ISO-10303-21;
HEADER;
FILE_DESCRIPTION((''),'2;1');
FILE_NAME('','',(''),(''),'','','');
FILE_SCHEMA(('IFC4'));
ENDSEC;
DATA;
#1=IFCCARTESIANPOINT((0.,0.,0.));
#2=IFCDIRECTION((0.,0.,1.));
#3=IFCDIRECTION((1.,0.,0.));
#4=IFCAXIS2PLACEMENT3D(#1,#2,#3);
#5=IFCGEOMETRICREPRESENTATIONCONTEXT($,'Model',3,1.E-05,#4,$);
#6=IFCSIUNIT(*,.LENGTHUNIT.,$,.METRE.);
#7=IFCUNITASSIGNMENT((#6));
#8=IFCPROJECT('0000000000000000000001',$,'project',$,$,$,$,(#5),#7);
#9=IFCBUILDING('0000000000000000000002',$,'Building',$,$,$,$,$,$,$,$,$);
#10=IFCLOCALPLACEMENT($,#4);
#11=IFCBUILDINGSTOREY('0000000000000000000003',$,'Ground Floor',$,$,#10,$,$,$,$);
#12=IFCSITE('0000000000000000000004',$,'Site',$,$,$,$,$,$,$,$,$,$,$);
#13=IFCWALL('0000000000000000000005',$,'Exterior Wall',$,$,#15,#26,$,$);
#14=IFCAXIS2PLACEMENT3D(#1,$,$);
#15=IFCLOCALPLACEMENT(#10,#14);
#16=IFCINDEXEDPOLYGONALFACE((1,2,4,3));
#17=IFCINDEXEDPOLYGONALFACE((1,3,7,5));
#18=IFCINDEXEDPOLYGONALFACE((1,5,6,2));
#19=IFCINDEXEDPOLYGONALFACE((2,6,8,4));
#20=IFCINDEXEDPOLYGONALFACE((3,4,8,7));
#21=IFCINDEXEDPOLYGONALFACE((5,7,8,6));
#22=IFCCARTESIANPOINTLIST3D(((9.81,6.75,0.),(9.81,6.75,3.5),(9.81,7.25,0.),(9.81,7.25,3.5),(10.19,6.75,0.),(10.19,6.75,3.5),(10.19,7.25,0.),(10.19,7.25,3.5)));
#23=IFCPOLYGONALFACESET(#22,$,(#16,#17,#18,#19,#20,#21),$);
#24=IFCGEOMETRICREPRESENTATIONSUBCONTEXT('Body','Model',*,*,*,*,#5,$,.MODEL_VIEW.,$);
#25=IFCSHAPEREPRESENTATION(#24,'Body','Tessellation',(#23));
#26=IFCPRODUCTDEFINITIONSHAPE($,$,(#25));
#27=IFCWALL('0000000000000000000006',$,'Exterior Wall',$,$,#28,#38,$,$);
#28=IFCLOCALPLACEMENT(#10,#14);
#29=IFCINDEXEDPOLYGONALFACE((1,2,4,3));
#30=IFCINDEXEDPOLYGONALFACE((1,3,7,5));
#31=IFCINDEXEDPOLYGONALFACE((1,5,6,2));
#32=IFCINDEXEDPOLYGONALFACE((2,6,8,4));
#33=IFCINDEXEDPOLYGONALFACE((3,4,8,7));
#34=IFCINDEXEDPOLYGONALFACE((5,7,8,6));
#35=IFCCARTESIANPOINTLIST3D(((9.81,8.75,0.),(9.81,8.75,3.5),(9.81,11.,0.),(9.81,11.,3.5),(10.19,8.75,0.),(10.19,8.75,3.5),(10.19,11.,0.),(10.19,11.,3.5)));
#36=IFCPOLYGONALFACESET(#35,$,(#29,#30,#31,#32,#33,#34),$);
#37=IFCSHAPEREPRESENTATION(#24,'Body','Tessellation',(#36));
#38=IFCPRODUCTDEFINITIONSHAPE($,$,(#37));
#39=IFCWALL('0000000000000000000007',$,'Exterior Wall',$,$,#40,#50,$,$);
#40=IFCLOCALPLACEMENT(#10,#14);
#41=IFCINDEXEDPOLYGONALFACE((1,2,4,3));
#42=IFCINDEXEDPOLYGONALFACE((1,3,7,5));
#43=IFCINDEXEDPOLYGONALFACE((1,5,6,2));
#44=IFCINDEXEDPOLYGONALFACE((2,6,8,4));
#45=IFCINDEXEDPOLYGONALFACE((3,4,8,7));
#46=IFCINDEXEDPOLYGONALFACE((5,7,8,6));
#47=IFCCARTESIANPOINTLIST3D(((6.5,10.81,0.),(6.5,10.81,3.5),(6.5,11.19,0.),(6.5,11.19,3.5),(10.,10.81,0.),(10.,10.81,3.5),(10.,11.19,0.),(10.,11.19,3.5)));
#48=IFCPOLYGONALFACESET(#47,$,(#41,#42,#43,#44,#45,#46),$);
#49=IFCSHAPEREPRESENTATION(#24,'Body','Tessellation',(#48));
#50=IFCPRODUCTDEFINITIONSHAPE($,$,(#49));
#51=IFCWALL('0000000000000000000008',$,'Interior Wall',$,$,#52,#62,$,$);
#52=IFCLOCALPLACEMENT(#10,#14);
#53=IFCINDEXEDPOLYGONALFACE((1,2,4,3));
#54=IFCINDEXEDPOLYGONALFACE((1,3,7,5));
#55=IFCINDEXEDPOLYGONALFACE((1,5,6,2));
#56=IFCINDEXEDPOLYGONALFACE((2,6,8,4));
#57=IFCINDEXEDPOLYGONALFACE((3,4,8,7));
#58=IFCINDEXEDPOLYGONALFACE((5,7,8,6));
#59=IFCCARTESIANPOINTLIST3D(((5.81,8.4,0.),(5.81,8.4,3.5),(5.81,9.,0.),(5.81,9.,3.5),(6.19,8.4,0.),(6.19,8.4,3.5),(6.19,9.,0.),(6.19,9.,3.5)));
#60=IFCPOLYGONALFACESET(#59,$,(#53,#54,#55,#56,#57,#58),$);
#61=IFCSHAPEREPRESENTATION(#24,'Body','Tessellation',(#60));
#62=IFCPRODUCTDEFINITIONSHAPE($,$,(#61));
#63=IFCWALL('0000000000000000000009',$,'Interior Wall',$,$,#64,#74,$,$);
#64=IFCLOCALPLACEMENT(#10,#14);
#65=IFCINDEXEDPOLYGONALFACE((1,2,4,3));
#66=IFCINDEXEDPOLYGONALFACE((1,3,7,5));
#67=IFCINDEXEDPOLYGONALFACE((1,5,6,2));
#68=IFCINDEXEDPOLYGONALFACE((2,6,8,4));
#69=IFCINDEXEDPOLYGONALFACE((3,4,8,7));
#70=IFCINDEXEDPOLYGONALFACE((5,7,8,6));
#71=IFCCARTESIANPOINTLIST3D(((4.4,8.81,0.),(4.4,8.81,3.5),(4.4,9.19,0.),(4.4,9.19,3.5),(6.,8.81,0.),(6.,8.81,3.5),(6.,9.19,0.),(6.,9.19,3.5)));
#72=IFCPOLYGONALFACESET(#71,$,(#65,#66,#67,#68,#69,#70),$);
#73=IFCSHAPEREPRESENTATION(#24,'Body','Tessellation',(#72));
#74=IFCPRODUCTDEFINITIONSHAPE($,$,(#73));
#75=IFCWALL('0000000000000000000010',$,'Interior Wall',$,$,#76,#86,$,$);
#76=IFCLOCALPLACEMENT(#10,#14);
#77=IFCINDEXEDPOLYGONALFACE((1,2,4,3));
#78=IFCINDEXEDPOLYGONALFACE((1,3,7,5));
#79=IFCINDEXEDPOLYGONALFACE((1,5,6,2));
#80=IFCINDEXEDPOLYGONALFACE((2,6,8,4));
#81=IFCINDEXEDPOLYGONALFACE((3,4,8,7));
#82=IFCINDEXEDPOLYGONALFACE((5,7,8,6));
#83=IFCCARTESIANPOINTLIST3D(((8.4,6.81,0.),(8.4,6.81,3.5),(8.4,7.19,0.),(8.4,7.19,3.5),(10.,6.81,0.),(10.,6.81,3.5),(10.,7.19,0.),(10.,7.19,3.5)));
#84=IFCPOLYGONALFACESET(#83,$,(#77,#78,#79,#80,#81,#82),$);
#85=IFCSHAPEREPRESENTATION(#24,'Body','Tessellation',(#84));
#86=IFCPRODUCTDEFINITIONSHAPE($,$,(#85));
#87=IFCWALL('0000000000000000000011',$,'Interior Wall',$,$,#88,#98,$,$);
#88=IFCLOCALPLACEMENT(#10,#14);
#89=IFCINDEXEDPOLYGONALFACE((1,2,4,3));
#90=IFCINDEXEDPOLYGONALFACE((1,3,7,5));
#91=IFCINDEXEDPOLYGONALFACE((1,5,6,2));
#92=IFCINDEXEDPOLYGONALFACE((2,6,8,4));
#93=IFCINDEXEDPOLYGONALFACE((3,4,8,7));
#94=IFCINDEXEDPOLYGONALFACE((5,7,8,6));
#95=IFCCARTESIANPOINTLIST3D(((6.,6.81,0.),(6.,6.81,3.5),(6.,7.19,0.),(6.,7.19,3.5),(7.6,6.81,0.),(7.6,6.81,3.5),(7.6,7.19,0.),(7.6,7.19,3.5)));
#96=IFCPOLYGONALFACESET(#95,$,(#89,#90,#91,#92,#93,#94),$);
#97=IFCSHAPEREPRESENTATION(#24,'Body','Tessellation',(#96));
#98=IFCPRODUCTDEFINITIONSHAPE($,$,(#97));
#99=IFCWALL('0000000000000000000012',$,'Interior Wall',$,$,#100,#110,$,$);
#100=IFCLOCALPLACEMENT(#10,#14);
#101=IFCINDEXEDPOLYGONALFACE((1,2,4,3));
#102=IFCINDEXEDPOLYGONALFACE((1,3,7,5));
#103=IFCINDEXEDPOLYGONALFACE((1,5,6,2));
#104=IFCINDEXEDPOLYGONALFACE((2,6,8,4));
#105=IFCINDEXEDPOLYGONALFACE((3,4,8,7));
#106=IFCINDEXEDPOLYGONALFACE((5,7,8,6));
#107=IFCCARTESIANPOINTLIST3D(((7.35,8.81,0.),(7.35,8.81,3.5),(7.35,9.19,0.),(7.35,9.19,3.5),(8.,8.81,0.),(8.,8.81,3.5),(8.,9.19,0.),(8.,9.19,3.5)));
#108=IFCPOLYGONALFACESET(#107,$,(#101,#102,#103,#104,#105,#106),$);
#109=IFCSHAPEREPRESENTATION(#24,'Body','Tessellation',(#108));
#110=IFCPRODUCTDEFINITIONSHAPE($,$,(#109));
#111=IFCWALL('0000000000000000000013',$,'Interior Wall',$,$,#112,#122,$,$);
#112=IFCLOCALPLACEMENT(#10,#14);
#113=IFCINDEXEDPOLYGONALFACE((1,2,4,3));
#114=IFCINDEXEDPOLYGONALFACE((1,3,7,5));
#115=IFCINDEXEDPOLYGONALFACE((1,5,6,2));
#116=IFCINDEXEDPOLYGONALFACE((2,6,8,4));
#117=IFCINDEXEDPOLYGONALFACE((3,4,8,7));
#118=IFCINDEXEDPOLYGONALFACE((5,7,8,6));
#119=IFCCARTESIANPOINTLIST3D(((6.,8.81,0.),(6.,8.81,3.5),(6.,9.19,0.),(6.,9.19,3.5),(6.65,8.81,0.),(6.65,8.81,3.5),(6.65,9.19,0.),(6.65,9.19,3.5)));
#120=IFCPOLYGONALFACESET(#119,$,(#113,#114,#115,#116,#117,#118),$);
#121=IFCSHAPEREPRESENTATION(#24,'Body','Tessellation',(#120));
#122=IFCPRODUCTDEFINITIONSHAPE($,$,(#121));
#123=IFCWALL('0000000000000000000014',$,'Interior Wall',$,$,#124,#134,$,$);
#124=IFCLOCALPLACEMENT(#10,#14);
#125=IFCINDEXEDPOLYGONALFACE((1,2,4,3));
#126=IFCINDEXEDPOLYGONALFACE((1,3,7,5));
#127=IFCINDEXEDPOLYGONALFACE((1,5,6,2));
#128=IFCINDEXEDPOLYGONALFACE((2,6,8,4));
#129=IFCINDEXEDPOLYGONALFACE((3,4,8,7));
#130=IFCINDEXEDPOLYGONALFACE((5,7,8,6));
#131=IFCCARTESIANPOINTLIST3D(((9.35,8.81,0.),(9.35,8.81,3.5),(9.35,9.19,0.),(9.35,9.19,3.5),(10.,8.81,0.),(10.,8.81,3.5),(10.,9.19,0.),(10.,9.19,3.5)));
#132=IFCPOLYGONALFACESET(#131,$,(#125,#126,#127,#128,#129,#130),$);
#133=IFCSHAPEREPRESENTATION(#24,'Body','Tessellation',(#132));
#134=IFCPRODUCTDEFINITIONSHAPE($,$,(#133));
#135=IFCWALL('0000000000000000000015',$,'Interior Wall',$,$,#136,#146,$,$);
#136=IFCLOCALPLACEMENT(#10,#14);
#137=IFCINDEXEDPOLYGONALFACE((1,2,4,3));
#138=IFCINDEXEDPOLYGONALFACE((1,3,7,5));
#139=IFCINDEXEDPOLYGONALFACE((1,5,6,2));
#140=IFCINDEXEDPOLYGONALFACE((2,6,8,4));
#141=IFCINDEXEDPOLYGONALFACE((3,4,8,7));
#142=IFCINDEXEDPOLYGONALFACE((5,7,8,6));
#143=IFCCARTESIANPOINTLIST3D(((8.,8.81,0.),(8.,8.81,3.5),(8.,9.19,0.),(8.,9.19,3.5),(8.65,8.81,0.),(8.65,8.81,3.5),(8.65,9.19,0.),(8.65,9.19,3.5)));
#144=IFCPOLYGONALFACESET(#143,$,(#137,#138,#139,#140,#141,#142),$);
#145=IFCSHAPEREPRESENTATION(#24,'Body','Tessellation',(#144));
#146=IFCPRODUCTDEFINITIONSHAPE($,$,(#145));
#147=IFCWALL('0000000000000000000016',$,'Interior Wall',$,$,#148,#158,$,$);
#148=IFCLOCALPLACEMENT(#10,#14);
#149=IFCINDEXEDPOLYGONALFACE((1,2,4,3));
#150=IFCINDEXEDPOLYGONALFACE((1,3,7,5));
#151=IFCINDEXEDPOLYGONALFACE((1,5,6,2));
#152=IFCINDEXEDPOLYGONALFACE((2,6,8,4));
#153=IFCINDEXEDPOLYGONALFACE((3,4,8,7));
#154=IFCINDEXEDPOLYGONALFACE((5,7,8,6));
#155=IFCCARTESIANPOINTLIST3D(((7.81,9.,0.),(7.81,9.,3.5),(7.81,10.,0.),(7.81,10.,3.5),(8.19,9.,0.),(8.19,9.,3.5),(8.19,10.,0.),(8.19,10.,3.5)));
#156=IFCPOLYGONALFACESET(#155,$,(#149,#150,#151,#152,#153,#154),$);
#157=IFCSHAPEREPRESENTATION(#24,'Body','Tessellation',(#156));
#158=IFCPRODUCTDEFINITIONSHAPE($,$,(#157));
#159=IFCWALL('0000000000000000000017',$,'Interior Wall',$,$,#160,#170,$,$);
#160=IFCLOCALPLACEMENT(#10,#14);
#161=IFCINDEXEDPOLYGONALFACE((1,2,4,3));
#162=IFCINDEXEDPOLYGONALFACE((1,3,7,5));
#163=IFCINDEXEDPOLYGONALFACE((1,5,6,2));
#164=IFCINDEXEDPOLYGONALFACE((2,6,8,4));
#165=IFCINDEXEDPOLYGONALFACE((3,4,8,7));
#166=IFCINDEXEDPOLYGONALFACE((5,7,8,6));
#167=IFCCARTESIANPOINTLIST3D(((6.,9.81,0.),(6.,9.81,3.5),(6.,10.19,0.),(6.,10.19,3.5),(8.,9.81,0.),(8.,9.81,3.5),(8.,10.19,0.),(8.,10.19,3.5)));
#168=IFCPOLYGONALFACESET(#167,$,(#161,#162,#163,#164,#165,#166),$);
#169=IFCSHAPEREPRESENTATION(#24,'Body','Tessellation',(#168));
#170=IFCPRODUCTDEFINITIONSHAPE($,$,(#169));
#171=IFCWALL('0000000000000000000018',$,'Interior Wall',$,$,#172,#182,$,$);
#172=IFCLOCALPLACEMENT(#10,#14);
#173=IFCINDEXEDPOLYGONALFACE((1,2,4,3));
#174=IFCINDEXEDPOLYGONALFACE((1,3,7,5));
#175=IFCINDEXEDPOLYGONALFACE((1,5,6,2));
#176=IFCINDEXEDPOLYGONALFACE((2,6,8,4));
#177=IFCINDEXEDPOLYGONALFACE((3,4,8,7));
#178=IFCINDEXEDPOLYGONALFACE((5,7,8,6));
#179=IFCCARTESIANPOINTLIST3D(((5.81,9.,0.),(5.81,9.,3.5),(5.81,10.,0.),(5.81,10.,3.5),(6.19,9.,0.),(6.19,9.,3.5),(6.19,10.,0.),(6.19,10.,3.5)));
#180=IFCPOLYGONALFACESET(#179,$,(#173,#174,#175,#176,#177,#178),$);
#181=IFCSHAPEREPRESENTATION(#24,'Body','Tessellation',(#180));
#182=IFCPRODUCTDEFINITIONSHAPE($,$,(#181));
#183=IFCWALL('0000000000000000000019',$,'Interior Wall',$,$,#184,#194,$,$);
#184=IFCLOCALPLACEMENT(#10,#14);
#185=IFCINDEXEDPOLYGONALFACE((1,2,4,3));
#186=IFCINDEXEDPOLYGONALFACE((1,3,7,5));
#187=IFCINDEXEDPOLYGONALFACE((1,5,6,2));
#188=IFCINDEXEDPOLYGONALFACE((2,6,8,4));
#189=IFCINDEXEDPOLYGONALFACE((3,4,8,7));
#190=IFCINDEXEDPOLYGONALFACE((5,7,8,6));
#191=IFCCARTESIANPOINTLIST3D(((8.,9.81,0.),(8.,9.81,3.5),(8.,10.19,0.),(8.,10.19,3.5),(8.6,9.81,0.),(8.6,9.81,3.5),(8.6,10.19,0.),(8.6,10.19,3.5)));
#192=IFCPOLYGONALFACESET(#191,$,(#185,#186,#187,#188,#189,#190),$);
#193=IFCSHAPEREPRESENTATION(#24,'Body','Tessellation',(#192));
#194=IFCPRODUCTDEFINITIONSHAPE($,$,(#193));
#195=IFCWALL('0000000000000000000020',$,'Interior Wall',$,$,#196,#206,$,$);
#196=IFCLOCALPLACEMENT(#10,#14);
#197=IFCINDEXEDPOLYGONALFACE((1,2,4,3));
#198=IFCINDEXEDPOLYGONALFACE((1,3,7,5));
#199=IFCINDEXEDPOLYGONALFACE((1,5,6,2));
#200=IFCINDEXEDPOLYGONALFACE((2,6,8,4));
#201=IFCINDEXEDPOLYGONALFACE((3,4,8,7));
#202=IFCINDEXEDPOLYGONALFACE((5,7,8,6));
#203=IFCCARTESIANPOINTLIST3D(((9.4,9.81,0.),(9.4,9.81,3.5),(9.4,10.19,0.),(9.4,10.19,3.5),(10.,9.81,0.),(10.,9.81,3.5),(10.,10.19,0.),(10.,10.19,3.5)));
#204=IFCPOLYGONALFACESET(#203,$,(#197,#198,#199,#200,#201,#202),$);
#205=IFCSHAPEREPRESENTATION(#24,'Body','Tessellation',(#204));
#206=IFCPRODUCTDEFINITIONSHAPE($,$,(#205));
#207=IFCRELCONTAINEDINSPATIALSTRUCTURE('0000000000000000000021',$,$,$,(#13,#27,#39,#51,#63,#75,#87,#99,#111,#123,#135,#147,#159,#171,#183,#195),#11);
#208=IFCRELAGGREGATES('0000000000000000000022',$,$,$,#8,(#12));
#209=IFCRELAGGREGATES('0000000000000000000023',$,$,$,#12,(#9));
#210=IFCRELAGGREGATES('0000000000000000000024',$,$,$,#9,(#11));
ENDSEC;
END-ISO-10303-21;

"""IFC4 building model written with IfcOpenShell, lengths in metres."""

from ifc_helpers import new_model, si_unit, frame, origin_with_axes, place, context, subcontext, project, spatial, indexed_curve, outline, extrude, element, save


model = new_model("IFC4")

# Units and contexts
model_context = context("Model", 3, precision=1e-05, world=origin_with_axes())
body_context = subcontext(model_context, "Body", "Model", "MODEL_VIEW")
ifc_project = project(units=[si_unit("LENGTHUNIT", "METRE")], contexts=[model_context])

# Site, building, storey
site = spatial("IfcSite", under=ifc_project, Name="Site")
building = spatial("IfcBuilding", under=site, Name="Building")
storey_placement = place(None, origin_with_axes())
storey = spatial("IfcBuildingStorey", under=building, at=storey_placement, Name="Ground Floor")

# Walls
wall_1_placement = place(storey_placement, frame((10.0, 6.75, 0.0), z_axis=(0.0, 0.0, 1.0), x_axis=(0.0, 1.0, 0.0)))
element("IfcWall", 1, at=wall_1_placement, inside=storey, Name="Exterior Wall", context=body_context, shape_type="SweptSolid", body=[
    extrude(outline(indexed_curve([(0.0, 0.0), (0.0, 0.38), (0.5, 0.38), (0.5, 0.0), (0.0, 0.0)], self_intersect=False)), frame((0.0, -0.19, 0.0), z_axis=(0.0, 0.0, 1.0), x_axis=(1.0, 0.0, 0.0)), (0.0, 0.0, 1.0), 3.5),
])
wall_2_placement = place(storey_placement, frame((10.0, 8.75, 0.0), z_axis=(0.0, 0.0, 1.0), x_axis=(0.0, 1.0, 0.0)))
element("IfcWall", 2, at=wall_2_placement, inside=storey, Name="Exterior Wall", context=body_context, shape_type="SweptSolid", body=[
    extrude(outline(indexed_curve([(0.0, 0.0), (0.0, 0.38), (2.25, 0.38), (2.25, 0.0), (0.0, 0.0)], self_intersect=False)), frame((0.0, -0.19, 0.0), z_axis=(0.0, 0.0, 1.0), x_axis=(1.0, 0.0, 0.0)), (0.0, 0.0, 1.0), 3.5),
])
wall_3_placement = place(storey_placement, frame((10.0, 11.0, 0.0), z_axis=(0.0, 0.0, 1.0), x_axis=(-1.0, 0.0, 0.0)))
element("IfcWall", 3, at=wall_3_placement, inside=storey, Name="Exterior Wall", context=body_context, shape_type="SweptSolid", body=[
    extrude(outline(indexed_curve([(0.0, 0.0), (0.0, 0.38), (3.5, 0.38), (3.5, 0.0), (0.0, 0.0)], self_intersect=False)), frame((0.0, -0.19, 0.0), z_axis=(0.0, 0.0, 1.0), x_axis=(1.0, 0.0, 0.0)), (0.0, 0.0, 1.0), 3.5),
])
wall_4_placement = place(storey_placement, frame((6.0, 8.4, 0.0), z_axis=(0.0, 0.0, 1.0), x_axis=(0.0, 1.0, 0.0)))
element("IfcWall", 4, at=wall_4_placement, inside=storey, Name="Interior Wall", context=body_context, shape_type="SweptSolid", body=[
    extrude(outline(indexed_curve([(0.0, 0.0), (0.0, 0.38), (0.6, 0.38), (0.6, 0.0), (0.0, 0.0)], self_intersect=False)), frame((0.0, -0.19, 0.0), z_axis=(0.0, 0.0, 1.0), x_axis=(1.0, 0.0, 0.0)), (0.0, 0.0, 1.0), 3.5),
])
for number, where, z_axis, x_axis, name in (
    (5, (6.0, 9.0, 0.0), (0.0, 0.0, 1.0), (-1.0, 0.0, 0.0), "Interior Wall"),
    (6, (10.0, 7.0, 0.0), (0.0, 0.0, 1.0), (-1.0, 0.0, 0.0), "Interior Wall"),
    (7, (7.6, 7.0, 0.0), (0.0, 0.0, 1.0), (-1.0, 0.0, 0.0), "Interior Wall"),
):
    element("IfcWall", number, at=place(storey_placement, frame(where, z_axis=z_axis, x_axis=x_axis)), inside=storey, Name=name, context=body_context, shape_type="SweptSolid", body=[
        extrude(outline(indexed_curve([(0.0, 0.0), (0.0, 0.38), (1.6, 0.38), (1.6, 0.0), (0.0, 0.0)], self_intersect=False)), frame((0.0, -0.19, 0.0), z_axis=(0.0, 0.0, 1.0), x_axis=(1.0, 0.0, 0.0)), (0.0, 0.0, 1.0), 3.5),
    ])
for number, where, z_axis, x_axis, name in (
    (8, (8.0, 9.0, 0.0), (0.0, 0.0, 1.0), (-1.0, 0.0, 0.0), "Interior Wall"),
    (9, (6.65, 9.0, 0.0), (0.0, 0.0, 1.0), (-1.0, 0.0, 0.0), "Interior Wall"),
    (10, (10.0, 9.0, 0.0), (0.0, 0.0, 1.0), (-1.0, 0.0, 0.0), "Interior Wall"),
    (11, (8.65, 9.0, 0.0), (0.0, 0.0, 1.0), (-1.0, 0.0, 0.0), "Interior Wall"),
):
    element("IfcWall", number, at=place(storey_placement, frame(where, z_axis=z_axis, x_axis=x_axis)), inside=storey, Name=name, context=body_context, shape_type="SweptSolid", body=[
        extrude(outline(indexed_curve([(0.0, 0.0), (0.0, 0.38), (0.65, 0.38), (0.65, 0.0), (0.0, 0.0)], self_intersect=False)), frame((0.0, -0.19, 0.0), z_axis=(0.0, 0.0, 1.0), x_axis=(1.0, 0.0, 0.0)), (0.0, 0.0, 1.0), 3.5),
    ])
wall_5_placement = place(storey_placement, frame((8.0, 9.0, 0.0), z_axis=(0.0, 0.0, 1.0), x_axis=(0.0, 1.0, 0.0)))
element("IfcWall", 12, at=wall_5_placement, inside=storey, Name="Interior Wall", context=body_context, shape_type="SweptSolid", body=[
    extrude(outline(indexed_curve([(0.0, 0.0), (0.0, 0.38), (1.0, 0.38), (1.0, 0.0), (0.0, 0.0)], self_intersect=False)), frame((0.0, -0.19, 0.0), z_axis=(0.0, 0.0, 1.0), x_axis=(1.0, 0.0, 0.0)), (0.0, 0.0, 1.0), 3.5),
])
wall_6_placement = place(storey_placement, frame((8.0, 10.0, 0.0), z_axis=(0.0, 0.0, 1.0), x_axis=(-1.0, 0.0, 0.0)))
element("IfcWall", 13, at=wall_6_placement, inside=storey, Name="Interior Wall", context=body_context, shape_type="SweptSolid", body=[
    extrude(outline(indexed_curve([(0.0, 0.0), (0.0, 0.38), (2.0, 0.38), (2.0, 0.0), (0.0, 0.0)], self_intersect=False)), frame((0.0, -0.19, 0.0), z_axis=(0.0, 0.0, 1.0), x_axis=(1.0, 0.0, 0.0)), (0.0, 0.0, 1.0), 3.5),
])
wall_7_placement = place(storey_placement, frame((6.0, 10.0, 0.0), z_axis=(0.0, 0.0, 1.0), x_axis=(0.0, -1.0, 0.0)))
element("IfcWall", 14, at=wall_7_placement, inside=storey, Name="Interior Wall", context=body_context, shape_type="SweptSolid", body=[
    extrude(outline(indexed_curve([(0.0, 0.0), (0.0, 0.38), (1.0, 0.38), (1.0, 0.0), (0.0, 0.0)], self_intersect=False)), frame((0.0, -0.19, 0.0), z_axis=(0.0, 0.0, 1.0), x_axis=(1.0, 0.0, 0.0)), (0.0, 0.0, 1.0), 3.5),
])
for number, where, z_axis, x_axis, name in (
    (15, (8.0, 10.0, 0.0), (0.0, 0.0, 1.0), (1.0, 0.0, 0.0), "Interior Wall"),
    (16, (9.4, 10.0, 0.0), (0.0, 0.0, 1.0), (1.0, 0.0, 0.0), "Interior Wall"),
):
    element("IfcWall", number, at=place(storey_placement, frame(where, z_axis=z_axis, x_axis=x_axis)), inside=storey, Name=name, context=body_context, shape_type="SweptSolid", body=[
        extrude(outline(indexed_curve([(0.0, 0.0), (0.0, 0.38), (0.6, 0.38), (0.6, 0.0), (0.0, 0.0)], self_intersect=False)), frame((0.0, -0.19, 0.0), z_axis=(0.0, 0.0, 1.0), x_axis=(1.0, 0.0, 0.0)), (0.0, 0.0, 1.0), 3.5),
    ])

save(model, "model.ifc")
